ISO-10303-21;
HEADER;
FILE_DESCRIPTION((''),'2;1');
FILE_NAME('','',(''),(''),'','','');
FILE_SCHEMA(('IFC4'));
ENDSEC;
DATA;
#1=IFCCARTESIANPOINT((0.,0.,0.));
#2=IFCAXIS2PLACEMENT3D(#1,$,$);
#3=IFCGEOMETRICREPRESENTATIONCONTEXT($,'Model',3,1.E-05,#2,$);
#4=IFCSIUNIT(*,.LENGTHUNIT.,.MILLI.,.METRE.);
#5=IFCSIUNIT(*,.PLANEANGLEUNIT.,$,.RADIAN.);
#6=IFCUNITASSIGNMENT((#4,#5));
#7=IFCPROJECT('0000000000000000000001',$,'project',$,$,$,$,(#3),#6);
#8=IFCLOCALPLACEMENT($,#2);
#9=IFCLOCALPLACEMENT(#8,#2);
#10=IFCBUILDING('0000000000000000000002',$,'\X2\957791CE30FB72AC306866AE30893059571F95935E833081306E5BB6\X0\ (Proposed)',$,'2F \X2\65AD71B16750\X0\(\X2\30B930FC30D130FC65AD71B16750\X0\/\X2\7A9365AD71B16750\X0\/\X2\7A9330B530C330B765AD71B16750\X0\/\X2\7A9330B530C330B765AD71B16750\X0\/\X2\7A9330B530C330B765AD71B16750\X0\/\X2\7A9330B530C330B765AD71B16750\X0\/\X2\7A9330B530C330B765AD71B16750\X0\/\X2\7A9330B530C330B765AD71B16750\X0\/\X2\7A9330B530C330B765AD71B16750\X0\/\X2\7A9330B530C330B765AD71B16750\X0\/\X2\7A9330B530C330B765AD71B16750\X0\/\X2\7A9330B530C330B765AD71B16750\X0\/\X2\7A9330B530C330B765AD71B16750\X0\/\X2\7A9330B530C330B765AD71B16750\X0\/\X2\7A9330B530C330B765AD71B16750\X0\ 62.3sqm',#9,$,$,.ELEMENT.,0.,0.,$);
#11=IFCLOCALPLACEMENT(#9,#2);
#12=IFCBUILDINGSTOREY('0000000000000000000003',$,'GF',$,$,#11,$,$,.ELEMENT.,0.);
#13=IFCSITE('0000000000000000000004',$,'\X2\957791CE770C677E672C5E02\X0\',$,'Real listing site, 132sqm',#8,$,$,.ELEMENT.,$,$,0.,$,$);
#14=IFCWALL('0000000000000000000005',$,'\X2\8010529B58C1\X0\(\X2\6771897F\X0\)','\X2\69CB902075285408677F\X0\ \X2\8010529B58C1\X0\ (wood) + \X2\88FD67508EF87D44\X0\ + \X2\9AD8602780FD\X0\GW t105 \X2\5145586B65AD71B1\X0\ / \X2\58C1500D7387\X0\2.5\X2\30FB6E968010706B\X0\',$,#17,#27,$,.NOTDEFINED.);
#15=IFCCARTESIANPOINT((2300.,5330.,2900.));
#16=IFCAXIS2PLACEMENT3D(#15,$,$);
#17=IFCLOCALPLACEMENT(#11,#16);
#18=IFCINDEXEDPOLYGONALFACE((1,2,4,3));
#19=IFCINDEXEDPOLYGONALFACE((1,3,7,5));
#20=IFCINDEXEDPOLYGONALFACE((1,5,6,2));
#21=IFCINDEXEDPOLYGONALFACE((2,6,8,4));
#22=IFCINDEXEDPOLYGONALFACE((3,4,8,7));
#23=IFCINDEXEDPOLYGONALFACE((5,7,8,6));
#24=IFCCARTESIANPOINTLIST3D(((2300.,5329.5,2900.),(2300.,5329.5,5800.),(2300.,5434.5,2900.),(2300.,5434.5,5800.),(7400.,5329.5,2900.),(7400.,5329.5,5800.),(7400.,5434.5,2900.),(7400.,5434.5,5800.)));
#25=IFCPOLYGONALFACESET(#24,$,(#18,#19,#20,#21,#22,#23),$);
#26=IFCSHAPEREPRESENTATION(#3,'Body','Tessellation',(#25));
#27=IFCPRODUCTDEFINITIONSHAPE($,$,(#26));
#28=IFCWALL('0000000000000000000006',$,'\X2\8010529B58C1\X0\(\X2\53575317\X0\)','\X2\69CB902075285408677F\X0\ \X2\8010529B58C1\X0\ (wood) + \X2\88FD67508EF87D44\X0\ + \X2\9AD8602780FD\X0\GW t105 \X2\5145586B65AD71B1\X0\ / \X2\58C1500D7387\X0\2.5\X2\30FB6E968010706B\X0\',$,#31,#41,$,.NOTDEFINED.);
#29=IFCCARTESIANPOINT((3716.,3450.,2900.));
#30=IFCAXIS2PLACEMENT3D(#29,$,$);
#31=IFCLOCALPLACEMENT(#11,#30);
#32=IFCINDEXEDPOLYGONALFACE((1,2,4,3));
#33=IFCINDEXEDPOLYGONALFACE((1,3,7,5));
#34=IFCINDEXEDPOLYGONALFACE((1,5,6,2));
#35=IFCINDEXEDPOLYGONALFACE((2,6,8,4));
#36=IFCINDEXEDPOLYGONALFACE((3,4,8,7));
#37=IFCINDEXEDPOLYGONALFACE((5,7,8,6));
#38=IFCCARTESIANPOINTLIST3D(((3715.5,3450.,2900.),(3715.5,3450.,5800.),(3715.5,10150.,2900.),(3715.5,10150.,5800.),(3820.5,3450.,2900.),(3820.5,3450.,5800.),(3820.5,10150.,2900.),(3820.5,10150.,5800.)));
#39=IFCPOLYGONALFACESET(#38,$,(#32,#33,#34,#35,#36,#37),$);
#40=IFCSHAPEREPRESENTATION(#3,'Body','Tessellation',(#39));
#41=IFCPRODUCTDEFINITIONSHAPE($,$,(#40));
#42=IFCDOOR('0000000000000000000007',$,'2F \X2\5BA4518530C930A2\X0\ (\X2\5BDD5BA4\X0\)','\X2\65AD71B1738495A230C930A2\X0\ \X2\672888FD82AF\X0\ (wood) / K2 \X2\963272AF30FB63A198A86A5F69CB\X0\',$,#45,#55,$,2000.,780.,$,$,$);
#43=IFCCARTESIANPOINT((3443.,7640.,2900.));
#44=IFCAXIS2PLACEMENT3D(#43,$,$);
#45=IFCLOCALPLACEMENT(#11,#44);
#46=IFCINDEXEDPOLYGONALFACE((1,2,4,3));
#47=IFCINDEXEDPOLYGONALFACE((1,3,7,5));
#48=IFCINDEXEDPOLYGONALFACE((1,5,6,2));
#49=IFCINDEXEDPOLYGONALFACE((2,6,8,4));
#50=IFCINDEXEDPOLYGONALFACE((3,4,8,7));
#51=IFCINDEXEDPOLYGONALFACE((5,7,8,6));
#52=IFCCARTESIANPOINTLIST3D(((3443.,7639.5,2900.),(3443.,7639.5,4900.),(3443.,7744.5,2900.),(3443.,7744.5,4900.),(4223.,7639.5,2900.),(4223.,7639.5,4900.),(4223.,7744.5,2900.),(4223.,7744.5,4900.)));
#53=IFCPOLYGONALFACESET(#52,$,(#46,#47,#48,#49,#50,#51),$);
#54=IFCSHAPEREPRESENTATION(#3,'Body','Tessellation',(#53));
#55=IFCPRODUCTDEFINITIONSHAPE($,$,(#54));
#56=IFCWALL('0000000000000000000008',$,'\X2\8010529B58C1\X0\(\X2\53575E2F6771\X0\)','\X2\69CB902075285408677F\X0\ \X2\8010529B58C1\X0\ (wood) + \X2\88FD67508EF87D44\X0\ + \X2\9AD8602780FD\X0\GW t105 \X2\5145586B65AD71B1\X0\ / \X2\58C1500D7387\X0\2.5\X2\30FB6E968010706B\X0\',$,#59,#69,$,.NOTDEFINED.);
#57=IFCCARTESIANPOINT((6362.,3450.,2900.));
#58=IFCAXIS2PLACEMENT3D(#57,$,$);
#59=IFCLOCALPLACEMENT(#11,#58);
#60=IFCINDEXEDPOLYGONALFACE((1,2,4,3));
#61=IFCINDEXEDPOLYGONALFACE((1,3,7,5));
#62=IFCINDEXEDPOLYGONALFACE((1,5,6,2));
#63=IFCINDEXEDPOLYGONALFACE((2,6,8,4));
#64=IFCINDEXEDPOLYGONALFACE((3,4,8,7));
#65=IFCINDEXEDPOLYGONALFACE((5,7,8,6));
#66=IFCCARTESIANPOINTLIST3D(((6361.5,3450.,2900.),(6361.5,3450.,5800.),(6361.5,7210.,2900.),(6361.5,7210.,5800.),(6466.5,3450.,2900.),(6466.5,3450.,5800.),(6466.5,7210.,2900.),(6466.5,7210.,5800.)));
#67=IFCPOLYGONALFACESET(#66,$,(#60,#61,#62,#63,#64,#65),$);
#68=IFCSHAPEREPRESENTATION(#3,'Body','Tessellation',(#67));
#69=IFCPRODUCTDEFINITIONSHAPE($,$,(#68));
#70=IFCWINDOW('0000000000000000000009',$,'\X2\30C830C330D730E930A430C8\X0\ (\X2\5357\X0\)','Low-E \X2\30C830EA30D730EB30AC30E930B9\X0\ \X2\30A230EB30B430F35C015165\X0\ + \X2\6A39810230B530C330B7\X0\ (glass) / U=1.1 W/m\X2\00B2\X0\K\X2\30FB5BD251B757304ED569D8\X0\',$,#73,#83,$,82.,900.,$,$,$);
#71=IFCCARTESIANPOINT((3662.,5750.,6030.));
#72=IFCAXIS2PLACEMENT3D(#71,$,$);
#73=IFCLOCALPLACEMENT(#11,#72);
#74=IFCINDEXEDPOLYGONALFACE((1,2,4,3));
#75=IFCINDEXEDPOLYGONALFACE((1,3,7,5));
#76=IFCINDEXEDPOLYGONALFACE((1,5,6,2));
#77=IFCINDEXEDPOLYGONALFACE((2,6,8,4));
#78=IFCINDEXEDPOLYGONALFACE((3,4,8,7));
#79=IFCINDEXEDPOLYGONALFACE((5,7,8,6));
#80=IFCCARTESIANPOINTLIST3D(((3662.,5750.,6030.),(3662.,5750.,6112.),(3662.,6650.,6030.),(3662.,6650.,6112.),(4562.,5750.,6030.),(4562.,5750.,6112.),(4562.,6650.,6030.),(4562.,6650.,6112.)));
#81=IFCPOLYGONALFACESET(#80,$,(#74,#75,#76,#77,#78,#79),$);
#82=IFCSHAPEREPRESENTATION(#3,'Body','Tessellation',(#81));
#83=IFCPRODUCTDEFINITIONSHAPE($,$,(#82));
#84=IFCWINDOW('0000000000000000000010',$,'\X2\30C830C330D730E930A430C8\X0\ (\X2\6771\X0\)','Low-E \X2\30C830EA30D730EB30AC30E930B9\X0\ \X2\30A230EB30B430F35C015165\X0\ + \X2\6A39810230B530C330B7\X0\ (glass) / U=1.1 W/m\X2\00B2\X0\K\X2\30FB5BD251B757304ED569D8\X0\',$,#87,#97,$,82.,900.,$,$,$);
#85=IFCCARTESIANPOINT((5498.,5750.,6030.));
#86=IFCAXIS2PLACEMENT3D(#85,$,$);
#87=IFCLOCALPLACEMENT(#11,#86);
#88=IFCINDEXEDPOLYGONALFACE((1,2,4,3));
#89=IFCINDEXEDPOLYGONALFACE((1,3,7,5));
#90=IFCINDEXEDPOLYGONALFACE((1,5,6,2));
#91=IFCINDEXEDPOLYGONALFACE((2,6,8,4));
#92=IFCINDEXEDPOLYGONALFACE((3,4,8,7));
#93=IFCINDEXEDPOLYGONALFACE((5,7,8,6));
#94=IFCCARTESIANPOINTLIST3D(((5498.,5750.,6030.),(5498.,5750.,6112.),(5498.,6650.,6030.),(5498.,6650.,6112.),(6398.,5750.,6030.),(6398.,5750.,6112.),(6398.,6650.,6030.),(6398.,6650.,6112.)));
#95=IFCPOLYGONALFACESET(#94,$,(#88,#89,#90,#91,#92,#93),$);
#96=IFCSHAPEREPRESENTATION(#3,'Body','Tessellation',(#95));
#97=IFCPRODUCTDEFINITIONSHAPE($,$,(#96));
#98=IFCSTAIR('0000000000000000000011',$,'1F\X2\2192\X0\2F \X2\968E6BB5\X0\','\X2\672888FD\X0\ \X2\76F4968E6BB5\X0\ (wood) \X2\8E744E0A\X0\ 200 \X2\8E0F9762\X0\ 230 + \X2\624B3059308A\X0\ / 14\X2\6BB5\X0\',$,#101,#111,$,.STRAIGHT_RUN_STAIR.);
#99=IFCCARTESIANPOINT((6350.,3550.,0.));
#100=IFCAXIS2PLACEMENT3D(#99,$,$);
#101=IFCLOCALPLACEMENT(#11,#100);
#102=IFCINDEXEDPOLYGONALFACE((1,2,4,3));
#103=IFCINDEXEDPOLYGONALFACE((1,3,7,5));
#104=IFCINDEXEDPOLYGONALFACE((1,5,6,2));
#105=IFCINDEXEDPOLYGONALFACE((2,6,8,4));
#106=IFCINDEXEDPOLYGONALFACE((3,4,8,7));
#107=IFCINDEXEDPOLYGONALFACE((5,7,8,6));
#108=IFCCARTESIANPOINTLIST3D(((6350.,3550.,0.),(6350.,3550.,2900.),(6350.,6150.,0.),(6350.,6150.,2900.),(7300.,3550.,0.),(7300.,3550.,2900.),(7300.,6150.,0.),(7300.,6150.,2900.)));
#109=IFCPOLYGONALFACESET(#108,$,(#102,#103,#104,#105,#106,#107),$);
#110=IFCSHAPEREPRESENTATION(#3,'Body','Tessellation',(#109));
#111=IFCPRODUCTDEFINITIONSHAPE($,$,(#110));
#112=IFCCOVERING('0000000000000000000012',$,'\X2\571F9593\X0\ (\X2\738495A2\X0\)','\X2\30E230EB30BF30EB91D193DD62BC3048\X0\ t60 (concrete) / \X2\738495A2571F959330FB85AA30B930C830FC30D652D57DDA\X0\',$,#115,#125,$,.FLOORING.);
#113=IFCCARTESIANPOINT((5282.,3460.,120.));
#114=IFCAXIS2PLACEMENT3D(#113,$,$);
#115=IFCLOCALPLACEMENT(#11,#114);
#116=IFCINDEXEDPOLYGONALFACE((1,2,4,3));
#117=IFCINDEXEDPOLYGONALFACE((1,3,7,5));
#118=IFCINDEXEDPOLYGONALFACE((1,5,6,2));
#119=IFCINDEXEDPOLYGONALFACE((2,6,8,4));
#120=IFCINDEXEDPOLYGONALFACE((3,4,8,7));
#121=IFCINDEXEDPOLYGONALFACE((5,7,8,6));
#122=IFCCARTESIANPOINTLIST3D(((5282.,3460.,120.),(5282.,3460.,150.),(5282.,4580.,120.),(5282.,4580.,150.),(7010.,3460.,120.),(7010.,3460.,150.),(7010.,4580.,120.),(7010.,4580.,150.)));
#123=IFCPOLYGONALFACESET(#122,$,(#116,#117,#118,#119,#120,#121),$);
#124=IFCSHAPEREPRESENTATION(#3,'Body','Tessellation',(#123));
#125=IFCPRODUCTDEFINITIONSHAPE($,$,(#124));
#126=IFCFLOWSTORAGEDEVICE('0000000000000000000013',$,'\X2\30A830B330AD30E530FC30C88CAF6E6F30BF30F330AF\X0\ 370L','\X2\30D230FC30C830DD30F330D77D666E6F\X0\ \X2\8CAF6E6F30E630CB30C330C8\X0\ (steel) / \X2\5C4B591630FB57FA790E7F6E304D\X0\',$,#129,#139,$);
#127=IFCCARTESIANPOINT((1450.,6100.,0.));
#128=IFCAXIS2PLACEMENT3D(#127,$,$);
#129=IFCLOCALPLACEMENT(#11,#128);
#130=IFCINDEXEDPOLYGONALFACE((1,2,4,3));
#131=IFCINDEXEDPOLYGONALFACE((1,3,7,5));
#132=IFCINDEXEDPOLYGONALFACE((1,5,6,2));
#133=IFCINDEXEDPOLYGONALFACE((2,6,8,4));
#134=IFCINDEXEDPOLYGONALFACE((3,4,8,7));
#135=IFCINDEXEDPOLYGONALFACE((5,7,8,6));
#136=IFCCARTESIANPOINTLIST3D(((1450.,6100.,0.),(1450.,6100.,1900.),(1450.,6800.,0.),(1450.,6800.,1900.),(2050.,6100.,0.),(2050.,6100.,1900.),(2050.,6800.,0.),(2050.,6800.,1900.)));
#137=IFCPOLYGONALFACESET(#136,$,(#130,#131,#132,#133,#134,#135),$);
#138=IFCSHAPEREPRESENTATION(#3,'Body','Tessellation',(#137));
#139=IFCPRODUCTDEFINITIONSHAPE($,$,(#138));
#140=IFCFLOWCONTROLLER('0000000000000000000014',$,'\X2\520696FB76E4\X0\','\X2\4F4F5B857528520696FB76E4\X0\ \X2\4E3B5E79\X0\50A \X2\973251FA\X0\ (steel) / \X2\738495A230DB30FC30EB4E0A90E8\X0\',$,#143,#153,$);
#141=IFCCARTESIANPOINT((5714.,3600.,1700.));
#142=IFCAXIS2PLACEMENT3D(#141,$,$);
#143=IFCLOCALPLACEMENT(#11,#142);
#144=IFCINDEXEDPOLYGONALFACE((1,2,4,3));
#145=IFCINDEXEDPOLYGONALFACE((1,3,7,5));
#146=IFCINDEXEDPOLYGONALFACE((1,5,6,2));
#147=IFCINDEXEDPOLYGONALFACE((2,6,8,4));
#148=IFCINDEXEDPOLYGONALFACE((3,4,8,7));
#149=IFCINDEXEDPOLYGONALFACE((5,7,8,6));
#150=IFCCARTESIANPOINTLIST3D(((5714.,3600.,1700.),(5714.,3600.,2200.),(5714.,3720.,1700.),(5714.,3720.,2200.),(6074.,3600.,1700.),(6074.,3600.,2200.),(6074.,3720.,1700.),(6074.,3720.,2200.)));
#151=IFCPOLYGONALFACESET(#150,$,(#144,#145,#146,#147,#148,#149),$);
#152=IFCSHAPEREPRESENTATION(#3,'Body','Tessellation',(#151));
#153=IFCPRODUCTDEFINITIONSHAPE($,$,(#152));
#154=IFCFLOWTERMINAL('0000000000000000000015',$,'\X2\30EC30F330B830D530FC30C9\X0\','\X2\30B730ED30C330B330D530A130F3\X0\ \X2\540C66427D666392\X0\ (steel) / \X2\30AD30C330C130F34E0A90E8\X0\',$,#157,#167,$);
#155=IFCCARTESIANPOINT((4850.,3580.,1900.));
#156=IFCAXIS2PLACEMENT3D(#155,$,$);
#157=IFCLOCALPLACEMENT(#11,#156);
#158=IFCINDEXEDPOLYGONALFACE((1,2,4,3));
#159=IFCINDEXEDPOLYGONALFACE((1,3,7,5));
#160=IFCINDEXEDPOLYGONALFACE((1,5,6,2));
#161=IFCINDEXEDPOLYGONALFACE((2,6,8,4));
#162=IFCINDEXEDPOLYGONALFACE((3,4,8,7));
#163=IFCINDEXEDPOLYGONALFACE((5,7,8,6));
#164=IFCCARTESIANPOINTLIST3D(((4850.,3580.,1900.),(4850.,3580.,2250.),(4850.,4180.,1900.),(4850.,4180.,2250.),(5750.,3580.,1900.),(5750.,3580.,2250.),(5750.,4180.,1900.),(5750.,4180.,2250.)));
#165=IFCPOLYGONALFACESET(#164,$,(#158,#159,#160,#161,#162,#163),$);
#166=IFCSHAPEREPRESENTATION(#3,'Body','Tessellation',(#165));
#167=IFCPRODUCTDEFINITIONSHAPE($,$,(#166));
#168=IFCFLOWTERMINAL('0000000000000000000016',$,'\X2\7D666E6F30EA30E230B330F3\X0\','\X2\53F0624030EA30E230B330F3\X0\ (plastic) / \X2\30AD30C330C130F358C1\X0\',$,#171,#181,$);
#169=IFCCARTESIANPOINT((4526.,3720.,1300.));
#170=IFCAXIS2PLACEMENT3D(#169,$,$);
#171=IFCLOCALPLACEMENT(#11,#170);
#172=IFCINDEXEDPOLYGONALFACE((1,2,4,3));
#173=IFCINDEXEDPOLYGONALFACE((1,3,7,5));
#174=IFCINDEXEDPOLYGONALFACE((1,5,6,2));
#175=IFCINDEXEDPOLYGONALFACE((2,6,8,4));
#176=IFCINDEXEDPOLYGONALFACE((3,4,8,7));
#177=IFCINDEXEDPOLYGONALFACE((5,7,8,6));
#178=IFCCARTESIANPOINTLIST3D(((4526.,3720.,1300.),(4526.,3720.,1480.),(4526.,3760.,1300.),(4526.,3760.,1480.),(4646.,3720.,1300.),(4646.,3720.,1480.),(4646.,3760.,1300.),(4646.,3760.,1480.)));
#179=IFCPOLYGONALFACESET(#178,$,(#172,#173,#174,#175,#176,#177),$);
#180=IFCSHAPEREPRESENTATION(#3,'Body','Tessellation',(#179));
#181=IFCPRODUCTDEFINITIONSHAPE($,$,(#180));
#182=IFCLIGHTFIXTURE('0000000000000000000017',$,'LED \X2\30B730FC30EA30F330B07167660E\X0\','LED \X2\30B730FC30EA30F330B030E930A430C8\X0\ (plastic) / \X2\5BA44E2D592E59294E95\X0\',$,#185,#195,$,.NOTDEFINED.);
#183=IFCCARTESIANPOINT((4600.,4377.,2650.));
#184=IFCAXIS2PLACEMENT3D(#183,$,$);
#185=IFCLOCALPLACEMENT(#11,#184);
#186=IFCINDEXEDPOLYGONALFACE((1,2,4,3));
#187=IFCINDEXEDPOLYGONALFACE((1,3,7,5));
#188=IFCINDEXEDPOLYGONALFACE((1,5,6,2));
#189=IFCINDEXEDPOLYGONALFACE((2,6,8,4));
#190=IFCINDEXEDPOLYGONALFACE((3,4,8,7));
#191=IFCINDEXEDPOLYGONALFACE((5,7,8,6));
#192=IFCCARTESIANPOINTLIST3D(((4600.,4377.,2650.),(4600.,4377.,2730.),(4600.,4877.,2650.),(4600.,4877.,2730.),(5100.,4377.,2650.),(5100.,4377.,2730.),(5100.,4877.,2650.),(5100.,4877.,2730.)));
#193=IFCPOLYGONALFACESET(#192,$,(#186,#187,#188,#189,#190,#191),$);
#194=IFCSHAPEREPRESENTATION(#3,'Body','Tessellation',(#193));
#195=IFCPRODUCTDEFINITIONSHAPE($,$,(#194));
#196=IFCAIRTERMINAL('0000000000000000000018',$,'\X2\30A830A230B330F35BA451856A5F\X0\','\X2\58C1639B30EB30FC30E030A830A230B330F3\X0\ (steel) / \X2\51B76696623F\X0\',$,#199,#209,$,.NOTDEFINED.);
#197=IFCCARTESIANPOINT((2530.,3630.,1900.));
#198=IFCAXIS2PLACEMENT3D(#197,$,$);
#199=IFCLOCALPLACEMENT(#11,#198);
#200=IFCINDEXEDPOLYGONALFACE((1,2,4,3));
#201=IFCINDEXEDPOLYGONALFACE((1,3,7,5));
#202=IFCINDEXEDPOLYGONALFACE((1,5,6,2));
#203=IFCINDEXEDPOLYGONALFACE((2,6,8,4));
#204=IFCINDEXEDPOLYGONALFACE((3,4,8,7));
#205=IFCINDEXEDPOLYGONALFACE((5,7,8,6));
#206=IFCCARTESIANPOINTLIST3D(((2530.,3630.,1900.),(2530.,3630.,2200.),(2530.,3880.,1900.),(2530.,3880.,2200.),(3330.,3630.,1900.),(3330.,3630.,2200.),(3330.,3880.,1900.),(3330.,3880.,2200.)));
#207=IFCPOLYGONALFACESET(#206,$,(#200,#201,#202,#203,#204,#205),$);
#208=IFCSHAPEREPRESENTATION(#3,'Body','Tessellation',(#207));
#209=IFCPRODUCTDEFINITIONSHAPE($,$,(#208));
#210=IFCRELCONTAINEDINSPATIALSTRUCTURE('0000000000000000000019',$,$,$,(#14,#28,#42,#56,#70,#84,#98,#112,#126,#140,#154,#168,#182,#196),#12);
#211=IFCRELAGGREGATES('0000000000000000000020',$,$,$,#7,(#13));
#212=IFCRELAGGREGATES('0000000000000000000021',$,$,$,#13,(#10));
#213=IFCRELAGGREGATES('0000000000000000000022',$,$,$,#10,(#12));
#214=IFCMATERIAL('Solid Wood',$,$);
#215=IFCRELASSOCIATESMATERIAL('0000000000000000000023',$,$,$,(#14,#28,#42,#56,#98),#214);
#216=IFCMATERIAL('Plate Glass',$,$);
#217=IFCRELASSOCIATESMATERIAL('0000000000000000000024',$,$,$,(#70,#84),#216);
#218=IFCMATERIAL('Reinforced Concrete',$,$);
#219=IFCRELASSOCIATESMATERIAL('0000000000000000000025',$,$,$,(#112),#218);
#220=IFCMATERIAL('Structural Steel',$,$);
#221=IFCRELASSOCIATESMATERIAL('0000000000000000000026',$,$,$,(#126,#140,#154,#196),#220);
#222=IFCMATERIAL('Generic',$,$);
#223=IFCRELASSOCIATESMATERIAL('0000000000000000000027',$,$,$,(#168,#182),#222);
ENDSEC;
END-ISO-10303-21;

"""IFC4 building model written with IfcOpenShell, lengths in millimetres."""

from ifc_helpers import new_model, si_unit, frame, frame_2d, origin, place, context, project, spatial, rectangle, extrude, material, element, fill, save


model = new_model("IFC4")

# Units and contexts
model_context = context("Model", 3, precision=1e-05, world=origin())
ifc_project = project(units=[si_unit("LENGTHUNIT", "METRE", prefix="MILLI"), si_unit("PLANEANGLEUNIT", "RADIAN")], contexts=[model_context])

# Site, building, storey
site_placement = place(None, origin())
site = spatial("IfcSite", under=ifc_project, at=site_placement, Name="長野県松本市", ObjectType="Real listing site, 132sqm", CompositionType="ELEMENT", RefElevation=0.0)
building_placement = place(site_placement, origin())
building = spatial("IfcBuilding", under=site, at=building_placement, Name="長野・犬と暮らす土間広めの家 (Proposed)", ObjectType="2F 断熱材(スーパー断熱材/窓断熱材/窓サッシ断熱材/窓サッシ断熱材/窓サッシ断熱材/窓サッシ断熱材/窓サッシ断熱材/窓サッシ断熱材/窓サッシ断熱材/窓サッシ断熱材/窓サッシ断熱材/窓サッシ断熱材/窓サッシ断熱材/窓サッシ断熱材/窓サッシ断熱材 62.3sqm", CompositionType="ELEMENT", ElevationOfRefHeight=0.0, ElevationOfTerrain=0.0)
storey_placement = place(building_placement, origin())
storey = spatial("IfcBuildingStorey", under=building, at=storey_placement, Name="GF", CompositionType="ELEMENT", Elevation=0.0)

# Shared definitions
ifc_material_1 = material(Name="Solid Wood")

# Wall
wall_1_placement = place(storey_placement, frame((2300.0, 5330.0, 2900.0)))
element("IfcWall", 1, at=wall_1_placement, inside=storey, material=ifc_material_1, Name="耐力壁(東西)", Description="構造用合板 耐力壁 (wood) + 製材軸組 + 高性能GW t105 充填断熱 / 壁倍率2.5・準耐火", PredefinedType="NOTDEFINED", context=model_context, shape_type="SweptSolid", body=[
    extrude(rectangle(XDim=5100.0, YDim=105.0, at=frame_2d((2550.0, 52.0))), frame((2300.0, 5330.0, 2900.0)), (0.0, 0.0, 1.0), 2900.0),
])

# Wall, opening, door
wall_2_placement = place(storey_placement, frame((3716.0, 3450.0, 2900.0)))
wall_2 = element("IfcWall", 2, at=wall_2_placement, inside=storey, material=ifc_material_1, Name="耐力壁(南北)", Description="構造用合板 耐力壁 (wood) + 製材軸組 + 高性能GW t105 充填断熱 / 壁倍率2.5・準耐火", PredefinedType="NOTDEFINED", context=model_context, shape_type="SweptSolid", body=[
    extrude(rectangle(XDim=105.0, YDim=6700.0, at=frame_2d((52.0, 3350.0))), frame((3716.0, 3450.0, 2900.0)), (0.0, 0.0, 1.0), 2900.0),
])
opening_placement = place(storey_placement, frame((3443.0, 7640.0, 2900.0)))
opening = element("IfcOpeningElement", 3, at=opening_placement, cuts=wall_2, PredefinedType="NOTDEFINED", context=model_context, shape_type="SweptSolid", body=[
    extrude(rectangle(XDim=780.0, YDim=105.0, at=frame_2d((390.0, 52.0))), frame((3443.0, 7640.0, 2900.0)), (0.0, 0.0, 1.0), 2000.0),
])
door_placement = place(storey_placement, frame((3443.0, 7640.0, 2900.0)))
door = element("IfcDoor", 4, at=door_placement, inside=storey, material=ifc_material_1, Name="2F 室内ドア (寝室)", Description="断熱玄関ドア 木製芯 (wood) / K2 防犯・採風機構", OverallHeight=2000.0, OverallWidth=780.0, context=model_context, shape_type="SweptSolid", body=[
    extrude(rectangle(XDim=780.0, YDim=105.0, at=frame_2d((390.0, 52.0))), frame((3443.0, 7640.0, 2900.0)), (0.0, 0.0, 1.0), 2000.0),
])
fill(opening, door)

# Wall
wall_3_placement = place(storey_placement, frame((6362.0, 3450.0, 2900.0)))
element("IfcWall", 5, at=wall_3_placement, inside=storey, material=ifc_material_1, Name="耐力壁(南帯東)", Description="構造用合板 耐力壁 (wood) + 製材軸組 + 高性能GW t105 充填断熱 / 壁倍率2.5・準耐火", PredefinedType="NOTDEFINED", context=model_context, shape_type="SweptSolid", body=[
    extrude(rectangle(XDim=105.0, YDim=3760.0, at=frame_2d((52.0, 1880.0))), frame((6362.0, 3450.0, 2900.0)), (0.0, 0.0, 1.0), 2900.0),
])

# Windows
ifc_material_2 = material(Name="Plate Glass")
window_1_placement = place(storey_placement, frame((3662.0, 5750.0, 6030.0)))
element("IfcWindow", 6, at=window_1_placement, inside=storey, material=ifc_material_2, Name="トップライト (南)", Description="Low-E トリプルガラス アルゴン封入 + 樹脂サッシ (glass) / U=1.1 W/m²K・寒冷地仕様", OverallHeight=82.0, OverallWidth=900.0, context=model_context, shape_type="SweptSolid", body=[
    extrude(rectangle(XDim=900.0, YDim=900.0, at=frame_2d((450.0, 450.0))), frame((3662.0, 5750.0, 6030.0)), (0.0, 0.0, 1.0), 82.0),
])
window_2_placement = place(storey_placement, frame((5498.0, 5750.0, 6030.0)))
element("IfcWindow", 7, at=window_2_placement, inside=storey, material=ifc_material_2, Name="トップライト (東)", Description="Low-E トリプルガラス アルゴン封入 + 樹脂サッシ (glass) / U=1.1 W/m²K・寒冷地仕様", OverallHeight=82.0, OverallWidth=900.0, context=model_context, shape_type="SweptSolid", body=[
    extrude(rectangle(XDim=900.0, YDim=900.0, at=frame_2d((450.0, 450.0))), frame((5498.0, 5750.0, 6030.0)), (0.0, 0.0, 1.0), 82.0),
])

# Stair
stair_placement = place(storey_placement, frame((6350.0, 3550.0, 0.0)))
element("IfcStair", 8, at=stair_placement, inside=storey, material=ifc_material_1, Name="1F→2F 階段", Description="木製 直階段 (wood) 蹴上 200 踏面 230 + 手すり / 14段", PredefinedType="STRAIGHT_RUN_STAIR", context=model_context, shape_type="SweptSolid", body=[
    extrude(rectangle(XDim=950.0, YDim=2600.0, at=frame_2d((475.0, 1300.0))), frame((6350.0, 3550.0, 0.0)), (0.0, 0.0, 1.0), 2900.0),
])

# Covering
ifc_material_3 = material(Name="Reinforced Concrete")
covering_placement = place(storey_placement, frame((5282.0, 3460.0, 120.0)))
element("IfcCovering", 9, at=covering_placement, inside=storey, material=ifc_material_3, Name="土間 (玄関)", Description="モルタル金鏝押え t60 (concrete) / 玄関土間・薪ストーブ動線", PredefinedType="FLOORING", context=model_context, shape_type="SweptSolid", body=[
    extrude(rectangle(XDim=1728.0, YDim=1120.0, at=frame_2d((864.0, 560.0))), frame((5282.0, 3460.0, 120.0)), (0.0, 0.0, 1.0), 30.0),
])

# Flow storage device
ifc_material_4 = material(Name="Structural Steel")
flow_storage_device_placement = place(storey_placement, frame((1450.0, 6100.0, 0.0)))
element("IfcFlowStorageDevice", 10, at=flow_storage_device_placement, inside=storey, material=ifc_material_4, Name="エコキュート貯湯タンク 370L", Description="ヒートポンプ給湯 貯湯ユニット (steel) / 屋外・基礎置き", context=model_context, shape_type="SweptSolid", body=[
    extrude(rectangle(XDim=600.0, YDim=700.0, at=frame_2d((300.0, 350.0))), frame((1450.0, 6100.0, 0.0)), (0.0, 0.0, 1.0), 1900.0),
])

# Flow controller
flow_controller_placement = place(storey_placement, frame((5714.0, 3600.0, 1700.0)))
element("IfcFlowController", 11, at=flow_controller_placement, inside=storey, material=ifc_material_4, Name="分電盤", Description="住宅用分電盤 主幹50A 露出 (steel) / 玄関ホール上部", context=model_context, shape_type="SweptSolid", body=[
    extrude(rectangle(XDim=360.0, YDim=120.0, at=frame_2d((180.0, 60.0))), frame((5714.0, 3600.0, 1700.0)), (0.0, 0.0, 1.0), 500.0),
])

# Flow terminals
flow_terminal_1_placement = place(storey_placement, frame((4850.0, 3580.0, 1900.0)))
element("IfcFlowTerminal", 12, at=flow_terminal_1_placement, inside=storey, material=ifc_material_4, Name="レンジフード", Description="シロッコファン 同時給排 (steel) / キッチン上部", context=model_context, shape_type="SweptSolid", body=[
    extrude(rectangle(XDim=900.0, YDim=600.0, at=frame_2d((450.0, 300.0))), frame((4850.0, 3580.0, 1900.0)), (0.0, 0.0, 1.0), 350.0),
])
ifc_material_5 = material(Name="Generic")
flow_terminal_2_placement = place(storey_placement, frame((4526.0, 3720.0, 1300.0)))
element("IfcFlowTerminal", 13, at=flow_terminal_2_placement, inside=storey, material=ifc_material_5, Name="給湯リモコン", Description="台所リモコン (plastic) / キッチン壁", context=model_context, shape_type="SweptSolid", body=[
    extrude(rectangle(XDim=120.0, YDim=40.0, at=frame_2d((60.0, 20.0))), frame((4526.0, 3720.0, 1300.0)), (0.0, 0.0, 1.0), 180.0),
])

# Light fixture
light_fixture_1_placement = place(storey_placement, frame((4600.0, 4377.0, 2650.0)))
element("IfcLightFixture", 14, at=light_fixture_1_placement, inside=storey, material=ifc_material_5, Name="LED シーリング照明", Description="LED シーリングライト (plastic) / 室中央天井", PredefinedType="NOTDEFINED", context=model_context, shape_type="SweptSolid", body=[
    extrude(rectangle(XDim=500.0, YDim=500.0, at=frame_2d((250.0, 250.0))), frame((4600.0, 4377.0, 2650.0)), (0.0, 0.0, 1.0), 80.0),
])

# Air terminal
air_terminal_1_placement = place(storey_placement, frame((2530.0, 3630.0, 1900.0)))
element("IfcAirTerminal", 15, at=air_terminal_1_placement, inside=storey, material=ifc_material_4, Name="エアコン室内機", Description="壁掛ルームエアコン (steel) / 冷暖房", PredefinedType="NOTDEFINED", context=model_context, shape_type="SweptSolid", body=[
    extrude(rectangle(XDim=800.0, YDim=250.0, at=frame_2d((400.0, 125.0))), frame((2530.0, 3630.0, 1900.0)), (0.0, 0.0, 1.0), 300.0),
])

save(model, "model.ifc")
